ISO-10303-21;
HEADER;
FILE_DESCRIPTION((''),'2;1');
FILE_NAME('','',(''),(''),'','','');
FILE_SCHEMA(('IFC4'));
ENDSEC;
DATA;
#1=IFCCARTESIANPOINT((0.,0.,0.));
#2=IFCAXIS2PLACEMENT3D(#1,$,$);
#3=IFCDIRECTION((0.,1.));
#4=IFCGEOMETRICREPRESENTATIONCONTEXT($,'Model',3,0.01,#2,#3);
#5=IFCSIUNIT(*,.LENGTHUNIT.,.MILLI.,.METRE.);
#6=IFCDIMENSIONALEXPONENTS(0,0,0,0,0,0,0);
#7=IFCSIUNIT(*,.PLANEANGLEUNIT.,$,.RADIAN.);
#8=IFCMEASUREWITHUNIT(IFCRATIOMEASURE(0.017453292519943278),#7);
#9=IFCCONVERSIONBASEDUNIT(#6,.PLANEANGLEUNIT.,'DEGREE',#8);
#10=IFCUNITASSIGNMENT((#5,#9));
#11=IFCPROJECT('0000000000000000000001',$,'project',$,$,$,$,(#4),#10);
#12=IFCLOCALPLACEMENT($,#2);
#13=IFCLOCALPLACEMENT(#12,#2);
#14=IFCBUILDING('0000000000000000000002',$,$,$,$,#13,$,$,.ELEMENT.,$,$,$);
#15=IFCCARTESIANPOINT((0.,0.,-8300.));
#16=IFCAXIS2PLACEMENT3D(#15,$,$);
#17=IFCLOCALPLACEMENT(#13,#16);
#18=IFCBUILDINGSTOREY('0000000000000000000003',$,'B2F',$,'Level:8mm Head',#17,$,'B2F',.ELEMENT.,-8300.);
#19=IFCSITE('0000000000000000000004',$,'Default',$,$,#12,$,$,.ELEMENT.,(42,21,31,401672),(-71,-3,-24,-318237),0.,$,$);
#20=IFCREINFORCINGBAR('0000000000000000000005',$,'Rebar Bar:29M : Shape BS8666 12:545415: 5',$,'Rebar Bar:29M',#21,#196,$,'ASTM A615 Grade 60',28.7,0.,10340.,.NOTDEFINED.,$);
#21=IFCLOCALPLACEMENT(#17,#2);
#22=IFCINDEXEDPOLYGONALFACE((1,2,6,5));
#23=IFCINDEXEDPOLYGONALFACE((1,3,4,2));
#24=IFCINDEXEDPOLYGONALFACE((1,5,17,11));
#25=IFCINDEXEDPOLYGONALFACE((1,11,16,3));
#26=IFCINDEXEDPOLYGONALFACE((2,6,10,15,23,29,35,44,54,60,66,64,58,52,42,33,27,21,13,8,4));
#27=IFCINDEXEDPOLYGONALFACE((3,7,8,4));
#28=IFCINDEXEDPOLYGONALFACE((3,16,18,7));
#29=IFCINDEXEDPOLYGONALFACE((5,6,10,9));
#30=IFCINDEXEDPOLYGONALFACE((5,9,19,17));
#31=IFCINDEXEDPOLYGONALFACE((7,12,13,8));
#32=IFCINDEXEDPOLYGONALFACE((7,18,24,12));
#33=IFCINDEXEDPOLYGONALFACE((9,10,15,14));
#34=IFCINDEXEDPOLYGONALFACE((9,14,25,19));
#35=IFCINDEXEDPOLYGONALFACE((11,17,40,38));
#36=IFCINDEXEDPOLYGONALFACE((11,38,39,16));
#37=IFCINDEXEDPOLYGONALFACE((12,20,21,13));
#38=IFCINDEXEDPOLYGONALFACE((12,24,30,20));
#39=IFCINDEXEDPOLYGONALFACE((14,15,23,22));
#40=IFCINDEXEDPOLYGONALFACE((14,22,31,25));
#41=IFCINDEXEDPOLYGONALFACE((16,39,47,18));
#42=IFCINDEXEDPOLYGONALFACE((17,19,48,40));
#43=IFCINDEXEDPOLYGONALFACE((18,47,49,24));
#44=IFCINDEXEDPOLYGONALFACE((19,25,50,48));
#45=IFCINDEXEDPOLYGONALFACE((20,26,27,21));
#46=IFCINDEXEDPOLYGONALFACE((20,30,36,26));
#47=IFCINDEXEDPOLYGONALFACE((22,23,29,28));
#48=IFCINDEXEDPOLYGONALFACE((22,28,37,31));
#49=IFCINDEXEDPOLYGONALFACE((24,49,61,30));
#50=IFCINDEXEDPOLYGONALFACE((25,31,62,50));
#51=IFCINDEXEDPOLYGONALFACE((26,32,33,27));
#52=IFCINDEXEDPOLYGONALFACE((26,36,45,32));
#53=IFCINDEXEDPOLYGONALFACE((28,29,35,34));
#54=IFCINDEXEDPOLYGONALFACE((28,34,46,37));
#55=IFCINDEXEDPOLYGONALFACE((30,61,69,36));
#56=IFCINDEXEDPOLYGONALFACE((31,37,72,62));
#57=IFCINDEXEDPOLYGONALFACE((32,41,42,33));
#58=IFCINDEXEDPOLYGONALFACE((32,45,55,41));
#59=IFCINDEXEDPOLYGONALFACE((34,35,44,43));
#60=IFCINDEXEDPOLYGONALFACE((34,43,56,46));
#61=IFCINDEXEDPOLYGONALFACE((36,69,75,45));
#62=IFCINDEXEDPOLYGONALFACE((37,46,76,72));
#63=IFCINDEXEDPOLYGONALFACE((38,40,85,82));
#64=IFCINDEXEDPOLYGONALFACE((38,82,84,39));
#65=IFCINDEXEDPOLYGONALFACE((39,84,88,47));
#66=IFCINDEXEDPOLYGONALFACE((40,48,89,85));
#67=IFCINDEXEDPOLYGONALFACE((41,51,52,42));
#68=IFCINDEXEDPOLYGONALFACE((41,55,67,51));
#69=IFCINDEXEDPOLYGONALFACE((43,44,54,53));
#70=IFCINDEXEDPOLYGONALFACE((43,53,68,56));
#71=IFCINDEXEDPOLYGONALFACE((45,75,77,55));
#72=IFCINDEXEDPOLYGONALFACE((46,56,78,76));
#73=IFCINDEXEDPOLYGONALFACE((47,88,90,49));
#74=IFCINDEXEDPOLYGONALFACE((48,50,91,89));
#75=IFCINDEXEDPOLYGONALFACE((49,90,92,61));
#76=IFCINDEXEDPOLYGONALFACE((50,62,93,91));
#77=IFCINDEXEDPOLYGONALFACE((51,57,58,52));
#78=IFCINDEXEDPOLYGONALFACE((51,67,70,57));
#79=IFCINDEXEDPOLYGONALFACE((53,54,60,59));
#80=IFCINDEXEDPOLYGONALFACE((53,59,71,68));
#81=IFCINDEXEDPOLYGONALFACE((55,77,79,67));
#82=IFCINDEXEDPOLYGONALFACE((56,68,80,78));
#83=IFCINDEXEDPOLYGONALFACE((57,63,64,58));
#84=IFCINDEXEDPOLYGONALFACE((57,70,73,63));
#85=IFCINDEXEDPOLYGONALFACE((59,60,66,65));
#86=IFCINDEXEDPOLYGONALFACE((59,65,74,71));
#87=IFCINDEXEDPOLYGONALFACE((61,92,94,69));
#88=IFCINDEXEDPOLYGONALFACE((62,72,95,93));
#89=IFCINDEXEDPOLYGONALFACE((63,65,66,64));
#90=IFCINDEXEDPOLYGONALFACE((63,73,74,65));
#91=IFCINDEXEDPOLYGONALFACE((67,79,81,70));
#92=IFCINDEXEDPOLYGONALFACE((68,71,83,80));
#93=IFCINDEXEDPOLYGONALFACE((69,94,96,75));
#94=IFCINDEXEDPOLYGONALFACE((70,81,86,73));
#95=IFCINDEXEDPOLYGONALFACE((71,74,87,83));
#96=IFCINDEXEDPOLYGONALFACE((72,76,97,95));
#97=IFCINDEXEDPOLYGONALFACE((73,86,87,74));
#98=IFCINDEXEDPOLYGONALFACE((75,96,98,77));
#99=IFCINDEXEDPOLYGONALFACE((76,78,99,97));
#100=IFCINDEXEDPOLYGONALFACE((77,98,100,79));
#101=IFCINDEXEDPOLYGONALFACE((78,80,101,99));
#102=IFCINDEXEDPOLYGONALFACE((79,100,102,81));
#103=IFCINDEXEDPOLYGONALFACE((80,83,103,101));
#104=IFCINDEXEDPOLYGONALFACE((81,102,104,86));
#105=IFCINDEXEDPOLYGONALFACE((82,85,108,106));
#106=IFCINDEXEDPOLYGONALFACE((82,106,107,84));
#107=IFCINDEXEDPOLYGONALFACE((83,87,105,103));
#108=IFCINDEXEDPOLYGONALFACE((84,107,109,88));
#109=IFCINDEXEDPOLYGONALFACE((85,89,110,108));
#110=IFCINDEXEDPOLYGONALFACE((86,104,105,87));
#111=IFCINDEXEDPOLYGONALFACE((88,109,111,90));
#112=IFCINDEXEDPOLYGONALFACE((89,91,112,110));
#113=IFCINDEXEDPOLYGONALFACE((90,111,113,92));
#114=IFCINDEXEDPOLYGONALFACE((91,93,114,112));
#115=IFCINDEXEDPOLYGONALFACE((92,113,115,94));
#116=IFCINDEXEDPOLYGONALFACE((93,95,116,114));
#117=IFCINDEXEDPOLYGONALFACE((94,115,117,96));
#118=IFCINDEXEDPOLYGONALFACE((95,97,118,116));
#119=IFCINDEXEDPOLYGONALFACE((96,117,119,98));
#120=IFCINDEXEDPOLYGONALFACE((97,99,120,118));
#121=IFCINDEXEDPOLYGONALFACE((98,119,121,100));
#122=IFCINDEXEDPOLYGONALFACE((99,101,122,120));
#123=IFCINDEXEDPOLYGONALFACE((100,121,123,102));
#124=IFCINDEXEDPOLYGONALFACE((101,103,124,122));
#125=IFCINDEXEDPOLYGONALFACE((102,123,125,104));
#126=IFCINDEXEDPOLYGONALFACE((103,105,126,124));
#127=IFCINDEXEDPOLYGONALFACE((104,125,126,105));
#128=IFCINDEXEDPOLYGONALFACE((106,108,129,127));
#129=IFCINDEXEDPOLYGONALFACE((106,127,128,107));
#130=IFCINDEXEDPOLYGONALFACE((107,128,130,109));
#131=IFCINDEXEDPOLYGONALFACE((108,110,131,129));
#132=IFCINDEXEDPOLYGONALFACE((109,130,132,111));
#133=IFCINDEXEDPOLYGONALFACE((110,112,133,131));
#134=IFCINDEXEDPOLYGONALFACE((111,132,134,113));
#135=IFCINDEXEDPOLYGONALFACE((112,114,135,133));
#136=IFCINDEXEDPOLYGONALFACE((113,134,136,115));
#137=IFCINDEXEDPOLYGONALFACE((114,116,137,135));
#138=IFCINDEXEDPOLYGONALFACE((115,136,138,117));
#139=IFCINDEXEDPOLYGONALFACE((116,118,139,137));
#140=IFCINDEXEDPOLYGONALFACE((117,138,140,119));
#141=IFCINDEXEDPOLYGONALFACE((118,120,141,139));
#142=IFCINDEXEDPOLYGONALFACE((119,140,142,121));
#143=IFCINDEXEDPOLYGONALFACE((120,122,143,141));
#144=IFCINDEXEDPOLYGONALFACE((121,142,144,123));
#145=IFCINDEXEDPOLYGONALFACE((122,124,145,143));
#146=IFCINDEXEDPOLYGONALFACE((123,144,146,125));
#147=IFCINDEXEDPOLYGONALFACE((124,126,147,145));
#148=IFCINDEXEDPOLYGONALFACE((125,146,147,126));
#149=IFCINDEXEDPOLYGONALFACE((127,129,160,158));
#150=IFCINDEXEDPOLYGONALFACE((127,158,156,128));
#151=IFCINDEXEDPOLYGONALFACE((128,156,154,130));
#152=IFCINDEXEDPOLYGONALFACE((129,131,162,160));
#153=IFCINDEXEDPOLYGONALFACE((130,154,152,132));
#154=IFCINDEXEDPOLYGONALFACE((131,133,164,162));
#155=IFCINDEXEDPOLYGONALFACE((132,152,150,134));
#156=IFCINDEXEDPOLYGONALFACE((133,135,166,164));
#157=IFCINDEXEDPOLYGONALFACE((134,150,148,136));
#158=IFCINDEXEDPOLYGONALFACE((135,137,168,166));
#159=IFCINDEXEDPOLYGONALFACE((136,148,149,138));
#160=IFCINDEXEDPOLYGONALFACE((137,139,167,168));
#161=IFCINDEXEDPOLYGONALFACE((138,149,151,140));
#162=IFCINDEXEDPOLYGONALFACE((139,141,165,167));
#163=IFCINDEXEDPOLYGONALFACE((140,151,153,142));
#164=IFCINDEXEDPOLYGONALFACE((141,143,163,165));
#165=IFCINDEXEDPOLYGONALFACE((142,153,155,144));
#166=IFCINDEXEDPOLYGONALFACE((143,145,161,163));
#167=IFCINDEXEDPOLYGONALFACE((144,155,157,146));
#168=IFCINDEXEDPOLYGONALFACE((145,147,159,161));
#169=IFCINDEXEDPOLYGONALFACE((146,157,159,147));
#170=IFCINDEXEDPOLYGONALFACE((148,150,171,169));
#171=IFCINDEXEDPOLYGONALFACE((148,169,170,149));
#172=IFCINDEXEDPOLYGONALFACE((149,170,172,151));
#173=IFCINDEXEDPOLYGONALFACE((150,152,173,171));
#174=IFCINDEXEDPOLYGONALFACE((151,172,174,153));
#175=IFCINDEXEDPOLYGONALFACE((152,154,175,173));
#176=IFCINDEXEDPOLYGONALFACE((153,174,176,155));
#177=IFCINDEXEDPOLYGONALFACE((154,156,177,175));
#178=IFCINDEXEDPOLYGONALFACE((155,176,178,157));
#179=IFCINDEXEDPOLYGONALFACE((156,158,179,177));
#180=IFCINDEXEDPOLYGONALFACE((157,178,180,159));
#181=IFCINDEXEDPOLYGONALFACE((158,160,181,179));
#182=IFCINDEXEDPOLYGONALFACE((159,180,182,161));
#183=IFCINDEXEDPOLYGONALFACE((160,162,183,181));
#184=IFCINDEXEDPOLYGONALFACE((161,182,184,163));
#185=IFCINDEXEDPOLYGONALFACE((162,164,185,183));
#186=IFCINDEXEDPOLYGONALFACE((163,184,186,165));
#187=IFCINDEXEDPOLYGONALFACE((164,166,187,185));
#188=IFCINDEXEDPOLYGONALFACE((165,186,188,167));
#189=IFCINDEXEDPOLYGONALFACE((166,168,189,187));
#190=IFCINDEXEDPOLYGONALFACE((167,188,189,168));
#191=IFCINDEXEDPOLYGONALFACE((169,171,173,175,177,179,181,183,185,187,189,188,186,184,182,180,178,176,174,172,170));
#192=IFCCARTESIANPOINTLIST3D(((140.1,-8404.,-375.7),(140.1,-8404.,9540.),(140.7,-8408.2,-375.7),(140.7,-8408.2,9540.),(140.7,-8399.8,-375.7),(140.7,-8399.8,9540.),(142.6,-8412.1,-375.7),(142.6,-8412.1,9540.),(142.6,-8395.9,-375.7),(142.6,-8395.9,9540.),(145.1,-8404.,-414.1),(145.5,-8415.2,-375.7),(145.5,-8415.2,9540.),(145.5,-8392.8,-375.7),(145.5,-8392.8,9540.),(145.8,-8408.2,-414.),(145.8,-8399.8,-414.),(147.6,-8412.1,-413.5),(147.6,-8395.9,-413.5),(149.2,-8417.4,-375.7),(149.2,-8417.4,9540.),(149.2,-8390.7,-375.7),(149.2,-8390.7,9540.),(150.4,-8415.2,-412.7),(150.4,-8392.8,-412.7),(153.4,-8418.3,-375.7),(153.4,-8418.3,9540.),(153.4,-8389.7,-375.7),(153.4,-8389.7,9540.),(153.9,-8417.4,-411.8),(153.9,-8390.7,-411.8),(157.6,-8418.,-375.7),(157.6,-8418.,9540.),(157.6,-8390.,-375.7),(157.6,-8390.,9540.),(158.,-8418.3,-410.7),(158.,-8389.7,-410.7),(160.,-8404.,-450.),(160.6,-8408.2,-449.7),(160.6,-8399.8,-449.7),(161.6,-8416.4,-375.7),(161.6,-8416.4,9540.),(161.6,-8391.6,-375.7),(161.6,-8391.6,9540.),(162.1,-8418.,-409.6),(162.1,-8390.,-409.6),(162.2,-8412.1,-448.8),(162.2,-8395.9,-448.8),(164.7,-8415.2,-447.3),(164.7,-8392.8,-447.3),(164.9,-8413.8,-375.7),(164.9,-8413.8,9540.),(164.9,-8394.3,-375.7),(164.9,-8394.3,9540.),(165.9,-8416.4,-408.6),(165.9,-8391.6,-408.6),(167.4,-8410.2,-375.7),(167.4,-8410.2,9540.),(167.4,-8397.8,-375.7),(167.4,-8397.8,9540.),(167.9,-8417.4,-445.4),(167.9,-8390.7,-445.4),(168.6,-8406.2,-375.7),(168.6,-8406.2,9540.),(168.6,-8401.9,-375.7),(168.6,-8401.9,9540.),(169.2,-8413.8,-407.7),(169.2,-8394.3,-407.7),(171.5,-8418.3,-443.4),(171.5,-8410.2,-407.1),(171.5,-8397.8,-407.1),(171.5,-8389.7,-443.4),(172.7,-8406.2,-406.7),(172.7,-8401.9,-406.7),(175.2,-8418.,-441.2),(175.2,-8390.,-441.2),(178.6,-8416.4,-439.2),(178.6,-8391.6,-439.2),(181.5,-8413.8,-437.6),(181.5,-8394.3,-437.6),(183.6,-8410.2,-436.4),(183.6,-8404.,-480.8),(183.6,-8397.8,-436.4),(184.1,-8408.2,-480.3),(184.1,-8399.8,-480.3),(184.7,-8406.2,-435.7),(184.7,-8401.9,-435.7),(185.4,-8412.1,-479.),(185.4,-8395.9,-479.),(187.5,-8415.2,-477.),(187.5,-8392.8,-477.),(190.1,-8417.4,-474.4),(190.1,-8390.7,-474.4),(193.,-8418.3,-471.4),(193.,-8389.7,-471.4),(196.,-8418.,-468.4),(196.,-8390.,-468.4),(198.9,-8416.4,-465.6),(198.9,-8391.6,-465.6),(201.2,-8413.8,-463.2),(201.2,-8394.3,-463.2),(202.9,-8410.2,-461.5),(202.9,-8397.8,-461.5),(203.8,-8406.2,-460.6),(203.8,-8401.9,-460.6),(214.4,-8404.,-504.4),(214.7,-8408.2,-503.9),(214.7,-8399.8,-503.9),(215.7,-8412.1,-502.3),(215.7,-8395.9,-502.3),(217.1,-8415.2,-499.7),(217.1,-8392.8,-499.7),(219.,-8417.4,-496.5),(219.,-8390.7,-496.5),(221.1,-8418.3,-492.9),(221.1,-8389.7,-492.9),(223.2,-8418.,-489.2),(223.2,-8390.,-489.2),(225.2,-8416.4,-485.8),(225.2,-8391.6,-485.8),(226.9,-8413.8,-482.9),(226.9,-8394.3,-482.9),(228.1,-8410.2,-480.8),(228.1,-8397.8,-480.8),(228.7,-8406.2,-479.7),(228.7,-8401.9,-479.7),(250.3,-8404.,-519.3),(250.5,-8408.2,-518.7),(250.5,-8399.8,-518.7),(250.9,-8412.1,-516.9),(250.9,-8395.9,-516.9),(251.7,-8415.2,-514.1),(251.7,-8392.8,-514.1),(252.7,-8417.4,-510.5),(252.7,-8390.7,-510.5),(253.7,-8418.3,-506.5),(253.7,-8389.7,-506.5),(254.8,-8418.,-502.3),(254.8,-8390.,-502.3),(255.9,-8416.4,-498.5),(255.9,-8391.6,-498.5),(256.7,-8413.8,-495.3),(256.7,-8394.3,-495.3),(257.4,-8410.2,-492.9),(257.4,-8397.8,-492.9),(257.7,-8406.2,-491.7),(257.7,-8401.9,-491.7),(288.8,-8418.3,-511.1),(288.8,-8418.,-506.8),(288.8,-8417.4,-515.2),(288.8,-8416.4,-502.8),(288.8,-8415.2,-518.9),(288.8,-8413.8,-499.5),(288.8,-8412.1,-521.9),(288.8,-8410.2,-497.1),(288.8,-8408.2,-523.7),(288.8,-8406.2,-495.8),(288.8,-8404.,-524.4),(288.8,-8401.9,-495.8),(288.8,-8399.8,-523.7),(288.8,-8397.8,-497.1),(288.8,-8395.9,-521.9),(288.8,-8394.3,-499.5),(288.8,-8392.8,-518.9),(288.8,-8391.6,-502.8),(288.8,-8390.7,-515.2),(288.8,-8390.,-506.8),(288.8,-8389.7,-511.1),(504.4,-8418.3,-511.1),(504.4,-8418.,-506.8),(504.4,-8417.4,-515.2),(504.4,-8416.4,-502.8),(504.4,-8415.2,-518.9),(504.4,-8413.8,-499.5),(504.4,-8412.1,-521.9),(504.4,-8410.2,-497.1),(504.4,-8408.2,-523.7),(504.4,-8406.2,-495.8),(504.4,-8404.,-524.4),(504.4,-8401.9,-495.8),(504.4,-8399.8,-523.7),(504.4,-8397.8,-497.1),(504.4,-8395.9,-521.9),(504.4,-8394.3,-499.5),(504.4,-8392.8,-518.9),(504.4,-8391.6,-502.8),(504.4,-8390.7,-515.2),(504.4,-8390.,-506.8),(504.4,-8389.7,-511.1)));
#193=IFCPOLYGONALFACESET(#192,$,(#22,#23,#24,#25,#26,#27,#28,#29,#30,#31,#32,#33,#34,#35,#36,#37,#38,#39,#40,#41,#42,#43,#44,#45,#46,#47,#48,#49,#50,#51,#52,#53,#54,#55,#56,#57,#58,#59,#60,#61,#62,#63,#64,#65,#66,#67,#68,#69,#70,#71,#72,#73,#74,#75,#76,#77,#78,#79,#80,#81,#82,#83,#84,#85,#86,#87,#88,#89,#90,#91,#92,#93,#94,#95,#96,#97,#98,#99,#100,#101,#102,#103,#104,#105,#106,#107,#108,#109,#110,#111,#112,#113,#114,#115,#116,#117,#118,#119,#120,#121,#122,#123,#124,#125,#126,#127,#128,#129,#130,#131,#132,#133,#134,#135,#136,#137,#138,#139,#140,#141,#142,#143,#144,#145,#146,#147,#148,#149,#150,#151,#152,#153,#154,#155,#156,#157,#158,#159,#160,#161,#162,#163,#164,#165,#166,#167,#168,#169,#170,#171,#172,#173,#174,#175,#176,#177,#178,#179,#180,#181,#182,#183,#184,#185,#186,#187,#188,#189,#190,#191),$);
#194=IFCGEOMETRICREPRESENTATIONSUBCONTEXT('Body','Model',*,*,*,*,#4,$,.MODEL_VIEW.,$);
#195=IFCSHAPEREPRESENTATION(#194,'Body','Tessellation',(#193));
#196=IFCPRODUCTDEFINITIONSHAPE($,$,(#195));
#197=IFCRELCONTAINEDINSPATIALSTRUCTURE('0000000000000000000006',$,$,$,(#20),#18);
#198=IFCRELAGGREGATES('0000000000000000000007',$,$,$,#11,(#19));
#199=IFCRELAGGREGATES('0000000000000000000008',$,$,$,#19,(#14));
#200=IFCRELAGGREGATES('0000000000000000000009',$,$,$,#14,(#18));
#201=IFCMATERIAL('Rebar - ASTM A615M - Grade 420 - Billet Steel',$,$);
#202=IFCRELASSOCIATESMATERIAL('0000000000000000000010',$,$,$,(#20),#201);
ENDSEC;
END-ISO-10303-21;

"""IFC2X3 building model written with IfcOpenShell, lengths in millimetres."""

from ifc_helpers import new_model, entity, si_unit, converted_unit, direction, frame, origin, place, context, subcontext, project, spatial, material, element, save


model = new_model("IFC2X3")

# Units and contexts
model_context = context("Model", 3, precision=0.01, world=origin(), true_north=direction((0.0, 1.0)))
body_context = subcontext(model_context, "Body", "Model", "MODEL_VIEW")
ifc_project = project(units=[si_unit("LENGTHUNIT", "METRE", prefix="MILLI"), converted_unit("PLANEANGLEUNIT", "DEGREE", entity("IfcRatioMeasure", 0.017453292519943278), si_unit("PLANEANGLEUNIT", "RADIAN"), dimensions=[0, 0, 0, 0, 0, 0, 0])], contexts=[model_context])

# Site, building, storey
site_placement = place(None, origin())
site = spatial("IfcSite", under=ifc_project, at=site_placement, Name="Default", CompositionType="ELEMENT", RefLatitude=(42, 21, 31, 401672), RefLongitude=(-71, -3, -24, -318237), RefElevation=0.0)
building_placement = place(site_placement, origin())
building = spatial("IfcBuilding", under=site, at=building_placement, CompositionType="ELEMENT")
storey_placement = place(building_placement, frame((0.0, 0.0, -8300.0)))
storey = spatial("IfcBuildingStorey", under=building, at=storey_placement, Name="B2F", ObjectType="Level:8mm Head", LongName="B2F", CompositionType="ELEMENT", Elevation=-8300.0)

# Reinforcing bar
ifc_material_1 = material(Name="Rebar - ASTM A615M - Grade 420 - Billet Steel")
reinforcing_bar_1_placement = place(storey_placement, origin())
element("IfcReinforcingBar", 1, at=reinforcing_bar_1_placement, inside=storey, material=ifc_material_1, Name="Rebar Bar:29M : Shape BS8666 12:545415: 5", SteelGrade="ASTM A615 Grade 60", ObjectType="Rebar Bar:29M", BarLength=10340.0, BarRole="NOTDEFINED", CrossSectionArea=0.0, NominalDiameter=28.7, context=body_context, shape_type="AdvancedSweptSolid", body=[
    entity("IfcSweptDiskSolid", entity("IfcCompositeCurve", [entity("IfcCompositeCurveSegment", "CONTINUOUS", True, entity("IfcPolyline", [entity("IfcCartesianPoint", [154.4, -8404.0, 9540.0]), entity("IfcCartesianPoint", [154.4, -8404.0, -375.7])])), entity("IfcCompositeCurveSegment", "CONTINUOUS", True, entity("IfcTrimmedCurve", entity("IfcCircle", entity("IfcAxis2Placement3D", entity("IfcCartesianPoint", [288.8, -8404.0, -375.7]), entity("IfcDirection", [0.0, -1.0, 0.0]), entity("IfcDirection", [0.0, 0.0, -1.0])), 134.3), [entity("IfcParameterValue", 270.0)], [entity("IfcParameterValue", 360.0)], True, "PARAMETER")), entity("IfcCompositeCurveSegment", "CONTINUOUS", True, entity("IfcPolyline", [entity("IfcCartesianPoint", [288.8, -8404.0, -510.0]), entity("IfcCartesianPoint", [504.4, -8404.0, -510.0])]))], False), 14.3, None, 0.0, 92.0),
])

save(model, "model.ifc")
